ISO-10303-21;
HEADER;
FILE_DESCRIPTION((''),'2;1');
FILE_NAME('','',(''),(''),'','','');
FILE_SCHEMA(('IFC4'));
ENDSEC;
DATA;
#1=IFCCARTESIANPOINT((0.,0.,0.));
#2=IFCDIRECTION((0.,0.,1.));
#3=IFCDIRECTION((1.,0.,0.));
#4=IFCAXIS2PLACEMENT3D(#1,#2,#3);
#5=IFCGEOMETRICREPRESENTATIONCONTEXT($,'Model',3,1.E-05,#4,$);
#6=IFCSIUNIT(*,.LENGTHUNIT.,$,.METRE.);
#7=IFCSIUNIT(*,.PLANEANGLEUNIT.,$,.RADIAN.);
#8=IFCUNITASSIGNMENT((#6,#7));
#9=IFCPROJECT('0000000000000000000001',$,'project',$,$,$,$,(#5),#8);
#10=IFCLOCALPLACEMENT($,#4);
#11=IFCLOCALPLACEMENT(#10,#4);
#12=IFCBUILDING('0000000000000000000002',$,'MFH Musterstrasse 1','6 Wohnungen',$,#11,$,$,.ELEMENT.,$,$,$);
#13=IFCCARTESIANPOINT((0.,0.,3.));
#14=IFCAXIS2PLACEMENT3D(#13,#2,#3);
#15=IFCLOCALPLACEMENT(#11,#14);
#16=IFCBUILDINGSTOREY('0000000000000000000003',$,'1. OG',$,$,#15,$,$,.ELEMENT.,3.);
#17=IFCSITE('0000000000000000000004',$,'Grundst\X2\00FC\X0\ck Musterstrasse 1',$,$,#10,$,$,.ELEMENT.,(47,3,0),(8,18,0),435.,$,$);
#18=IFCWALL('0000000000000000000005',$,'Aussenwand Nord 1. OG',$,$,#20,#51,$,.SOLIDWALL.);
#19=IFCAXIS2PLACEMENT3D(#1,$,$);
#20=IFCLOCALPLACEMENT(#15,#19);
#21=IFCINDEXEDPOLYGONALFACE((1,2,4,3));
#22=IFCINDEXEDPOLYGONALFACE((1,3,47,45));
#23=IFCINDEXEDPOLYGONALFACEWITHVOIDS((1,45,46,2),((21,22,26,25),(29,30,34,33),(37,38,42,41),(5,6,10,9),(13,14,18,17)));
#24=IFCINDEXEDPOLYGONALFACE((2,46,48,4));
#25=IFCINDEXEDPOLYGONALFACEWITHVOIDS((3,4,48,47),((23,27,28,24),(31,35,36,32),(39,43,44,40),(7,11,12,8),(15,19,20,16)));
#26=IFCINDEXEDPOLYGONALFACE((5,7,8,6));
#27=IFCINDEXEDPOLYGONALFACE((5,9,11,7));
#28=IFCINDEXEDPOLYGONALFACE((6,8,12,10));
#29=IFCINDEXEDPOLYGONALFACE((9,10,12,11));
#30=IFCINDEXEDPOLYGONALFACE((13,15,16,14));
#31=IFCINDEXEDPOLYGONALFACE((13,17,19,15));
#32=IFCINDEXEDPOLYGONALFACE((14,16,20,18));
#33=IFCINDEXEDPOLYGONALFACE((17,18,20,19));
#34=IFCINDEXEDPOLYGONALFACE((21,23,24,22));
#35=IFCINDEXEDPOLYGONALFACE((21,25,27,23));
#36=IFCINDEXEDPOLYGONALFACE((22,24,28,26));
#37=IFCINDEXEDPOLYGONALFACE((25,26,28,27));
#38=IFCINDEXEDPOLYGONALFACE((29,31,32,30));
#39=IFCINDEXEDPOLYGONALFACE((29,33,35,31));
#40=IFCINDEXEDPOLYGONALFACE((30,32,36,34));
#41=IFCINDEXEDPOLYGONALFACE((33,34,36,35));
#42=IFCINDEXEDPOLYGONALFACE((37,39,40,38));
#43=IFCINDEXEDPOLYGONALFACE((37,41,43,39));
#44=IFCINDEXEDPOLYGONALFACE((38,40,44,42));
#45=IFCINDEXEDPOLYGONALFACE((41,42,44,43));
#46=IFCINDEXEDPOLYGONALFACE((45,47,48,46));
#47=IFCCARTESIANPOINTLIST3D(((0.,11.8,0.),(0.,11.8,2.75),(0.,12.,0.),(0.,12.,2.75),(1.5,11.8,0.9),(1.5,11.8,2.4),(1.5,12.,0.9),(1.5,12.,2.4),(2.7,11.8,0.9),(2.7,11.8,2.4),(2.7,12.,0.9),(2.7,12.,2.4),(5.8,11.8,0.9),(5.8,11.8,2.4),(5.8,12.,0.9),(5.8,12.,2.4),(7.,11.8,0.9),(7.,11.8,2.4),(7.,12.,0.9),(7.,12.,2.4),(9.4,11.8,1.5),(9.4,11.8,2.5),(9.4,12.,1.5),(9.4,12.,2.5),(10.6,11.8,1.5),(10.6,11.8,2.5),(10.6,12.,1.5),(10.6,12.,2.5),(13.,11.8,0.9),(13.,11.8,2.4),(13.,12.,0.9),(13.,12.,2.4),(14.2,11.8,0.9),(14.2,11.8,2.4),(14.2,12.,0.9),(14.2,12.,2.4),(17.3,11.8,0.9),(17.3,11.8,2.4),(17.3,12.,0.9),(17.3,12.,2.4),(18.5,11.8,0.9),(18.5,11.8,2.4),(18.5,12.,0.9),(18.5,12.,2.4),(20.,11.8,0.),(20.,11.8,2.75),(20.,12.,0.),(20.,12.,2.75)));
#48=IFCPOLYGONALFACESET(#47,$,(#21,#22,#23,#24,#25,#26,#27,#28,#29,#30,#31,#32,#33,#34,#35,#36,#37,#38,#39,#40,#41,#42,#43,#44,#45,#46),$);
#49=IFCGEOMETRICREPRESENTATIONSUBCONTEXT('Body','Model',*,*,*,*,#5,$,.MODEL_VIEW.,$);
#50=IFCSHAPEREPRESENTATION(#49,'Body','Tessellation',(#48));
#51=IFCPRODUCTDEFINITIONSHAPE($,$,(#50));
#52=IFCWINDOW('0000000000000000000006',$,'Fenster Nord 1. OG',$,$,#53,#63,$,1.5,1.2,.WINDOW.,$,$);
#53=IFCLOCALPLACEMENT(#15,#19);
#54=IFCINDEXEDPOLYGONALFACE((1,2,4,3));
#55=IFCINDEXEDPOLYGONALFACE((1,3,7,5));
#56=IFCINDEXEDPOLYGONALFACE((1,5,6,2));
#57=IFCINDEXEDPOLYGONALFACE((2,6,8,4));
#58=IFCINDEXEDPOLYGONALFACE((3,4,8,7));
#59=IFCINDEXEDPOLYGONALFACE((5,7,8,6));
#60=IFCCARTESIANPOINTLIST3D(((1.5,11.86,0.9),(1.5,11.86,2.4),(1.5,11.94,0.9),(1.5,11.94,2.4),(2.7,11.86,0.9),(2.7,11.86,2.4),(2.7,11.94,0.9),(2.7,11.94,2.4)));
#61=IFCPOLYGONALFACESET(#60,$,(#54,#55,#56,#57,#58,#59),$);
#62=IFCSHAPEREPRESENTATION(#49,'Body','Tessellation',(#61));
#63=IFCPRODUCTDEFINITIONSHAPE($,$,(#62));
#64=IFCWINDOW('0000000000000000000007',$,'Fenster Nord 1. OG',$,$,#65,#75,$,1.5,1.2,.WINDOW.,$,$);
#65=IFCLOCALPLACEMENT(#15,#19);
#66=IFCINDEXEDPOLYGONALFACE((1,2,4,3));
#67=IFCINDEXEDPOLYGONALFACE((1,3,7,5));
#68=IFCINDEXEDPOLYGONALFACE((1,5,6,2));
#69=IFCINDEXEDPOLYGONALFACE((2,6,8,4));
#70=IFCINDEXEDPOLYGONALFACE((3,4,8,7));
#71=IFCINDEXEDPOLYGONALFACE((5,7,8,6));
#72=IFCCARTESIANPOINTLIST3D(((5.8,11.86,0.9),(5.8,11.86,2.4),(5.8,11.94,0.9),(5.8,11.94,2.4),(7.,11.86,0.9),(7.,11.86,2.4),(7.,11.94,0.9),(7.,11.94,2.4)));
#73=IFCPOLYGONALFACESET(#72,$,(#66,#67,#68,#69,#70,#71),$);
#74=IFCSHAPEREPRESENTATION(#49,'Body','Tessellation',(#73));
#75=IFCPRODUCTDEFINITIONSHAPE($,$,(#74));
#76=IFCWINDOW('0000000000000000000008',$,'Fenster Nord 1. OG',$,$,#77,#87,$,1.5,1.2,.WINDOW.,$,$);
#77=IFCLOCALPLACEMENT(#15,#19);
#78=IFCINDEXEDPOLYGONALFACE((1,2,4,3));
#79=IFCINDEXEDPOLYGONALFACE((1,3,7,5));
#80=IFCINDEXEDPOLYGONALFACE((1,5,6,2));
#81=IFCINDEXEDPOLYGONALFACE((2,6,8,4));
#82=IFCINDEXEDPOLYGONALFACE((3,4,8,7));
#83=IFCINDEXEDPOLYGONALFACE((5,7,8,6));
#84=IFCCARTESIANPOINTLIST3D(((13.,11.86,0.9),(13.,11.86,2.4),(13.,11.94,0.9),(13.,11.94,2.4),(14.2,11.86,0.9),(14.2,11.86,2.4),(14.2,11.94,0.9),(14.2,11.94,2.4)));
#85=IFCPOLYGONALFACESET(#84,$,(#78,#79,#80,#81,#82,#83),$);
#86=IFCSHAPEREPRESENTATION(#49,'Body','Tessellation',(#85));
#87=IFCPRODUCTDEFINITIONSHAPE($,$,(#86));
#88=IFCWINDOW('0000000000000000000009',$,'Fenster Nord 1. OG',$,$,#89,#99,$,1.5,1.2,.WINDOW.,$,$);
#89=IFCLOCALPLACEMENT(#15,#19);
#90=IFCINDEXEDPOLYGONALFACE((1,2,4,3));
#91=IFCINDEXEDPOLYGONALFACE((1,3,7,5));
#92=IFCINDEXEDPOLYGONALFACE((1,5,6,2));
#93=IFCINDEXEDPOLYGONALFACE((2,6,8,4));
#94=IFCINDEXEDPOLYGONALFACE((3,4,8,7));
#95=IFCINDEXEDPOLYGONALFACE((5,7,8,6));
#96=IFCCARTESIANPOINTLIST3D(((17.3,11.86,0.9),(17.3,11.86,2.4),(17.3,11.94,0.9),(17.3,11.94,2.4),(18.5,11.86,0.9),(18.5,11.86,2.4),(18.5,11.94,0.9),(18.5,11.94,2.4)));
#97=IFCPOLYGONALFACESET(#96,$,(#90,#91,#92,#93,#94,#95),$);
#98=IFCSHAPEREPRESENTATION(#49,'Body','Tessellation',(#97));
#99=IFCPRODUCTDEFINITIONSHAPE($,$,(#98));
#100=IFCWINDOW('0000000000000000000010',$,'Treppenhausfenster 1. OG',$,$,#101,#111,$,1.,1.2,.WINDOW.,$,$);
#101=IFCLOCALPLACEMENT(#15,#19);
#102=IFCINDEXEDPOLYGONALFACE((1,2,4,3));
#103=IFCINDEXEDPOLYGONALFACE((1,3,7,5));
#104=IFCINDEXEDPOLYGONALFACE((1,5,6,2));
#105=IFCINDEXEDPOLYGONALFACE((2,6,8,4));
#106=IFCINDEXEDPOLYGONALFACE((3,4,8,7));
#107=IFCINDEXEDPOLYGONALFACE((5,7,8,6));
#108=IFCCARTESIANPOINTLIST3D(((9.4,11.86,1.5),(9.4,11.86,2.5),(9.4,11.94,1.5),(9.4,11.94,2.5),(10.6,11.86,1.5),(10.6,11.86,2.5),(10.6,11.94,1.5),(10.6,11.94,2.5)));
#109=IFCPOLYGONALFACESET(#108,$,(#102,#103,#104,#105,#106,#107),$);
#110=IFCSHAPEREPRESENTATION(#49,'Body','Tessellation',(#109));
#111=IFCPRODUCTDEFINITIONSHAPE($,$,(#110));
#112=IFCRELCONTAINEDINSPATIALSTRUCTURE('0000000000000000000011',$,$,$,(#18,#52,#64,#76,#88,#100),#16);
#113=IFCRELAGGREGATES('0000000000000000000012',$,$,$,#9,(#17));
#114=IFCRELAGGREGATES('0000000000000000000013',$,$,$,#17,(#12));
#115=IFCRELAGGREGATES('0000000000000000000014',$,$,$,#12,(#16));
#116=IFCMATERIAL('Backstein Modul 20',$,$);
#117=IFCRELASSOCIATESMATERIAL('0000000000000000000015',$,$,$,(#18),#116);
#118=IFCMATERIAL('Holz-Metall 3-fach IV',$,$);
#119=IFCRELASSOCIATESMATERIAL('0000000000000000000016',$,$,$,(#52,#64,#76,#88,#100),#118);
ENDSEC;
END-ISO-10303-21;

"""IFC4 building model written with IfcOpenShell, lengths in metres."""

from ifc_helpers import new_model, si_unit, frame, frame_2d, origin_with_axes, place, context, subcontext, project, spatial, rectangle, extrude, material, element, fill, save


model = new_model("IFC4")

# Units and contexts
model_context = context("Model", 3, precision=1e-05, world=origin_with_axes())
body_context = subcontext(model_context, "Body", "Model", "MODEL_VIEW")
ifc_project = project(units=[si_unit("LENGTHUNIT", "METRE"), si_unit("PLANEANGLEUNIT", "RADIAN")], contexts=[model_context])

# Site, building, storey
site_placement = place(None, origin_with_axes())
site = spatial("IfcSite", under=ifc_project, at=site_placement, Name="Grundstück Musterstrasse 1", CompositionType="ELEMENT", RefLatitude=(47, 3, 0), RefLongitude=(8, 18, 0), RefElevation=435.0)
building_placement = place(site_placement, origin_with_axes())
building = spatial("IfcBuilding", under=site, at=building_placement, Name="MFH Musterstrasse 1", Description="6 Wohnungen", CompositionType="ELEMENT")
storey_placement = place(building_placement, frame((0.0, 0.0, 3.0), z_axis=(0.0, 0.0, 1.0), x_axis=(1.0, 0.0, 0.0)))
storey = spatial("IfcBuildingStorey", under=building, at=storey_placement, Name="1. OG", CompositionType="ELEMENT", Elevation=3.0)

# Shared definitions
ifc_material_1 = material(Name="Backstein Modul 20")
ifc_material_2 = material(Name="Holz-Metall 3-fach IV")

# Wall, openings, windows
wall_1_placement = place(storey_placement, origin_with_axes())
wall_1 = element("IfcWall", 1, at=wall_1_placement, inside=storey, material=ifc_material_1, Name="Aussenwand Nord 1. OG", PredefinedType="SOLIDWALL", context=body_context, shape_type="SweptSolid", body=[
    extrude(rectangle(XDim=20.0, YDim=0.2, at=frame_2d((10.0, 0.1), x_axis=(1.0, 0.0))), frame((0.0, 11.8, 0.0), z_axis=(0.0, 0.0, 1.0), x_axis=(1.0, 0.0, 0.0)), (0.0, 0.0, 1.0), 2.75),
])
opening_1_placement = place(storey_placement, origin_with_axes())
element("IfcOpeningElement", 2, at=opening_1_placement, cuts=wall_1, PredefinedType="OPENING", context=body_context, shape_type="SweptSolid", body=[
    extrude(rectangle(XDim=1.2, YDim=0.3, at=frame_2d((0.6, 0.15), x_axis=(1.0, 0.0))), frame((1.5, 11.75, 0.9), z_axis=(0.0, 0.0, 1.0), x_axis=(1.0, 0.0, 0.0)), (0.0, 0.0, 1.0), 1.5),
])
opening_2_placement = place(storey_placement, origin_with_axes())
element("IfcOpeningElement", 3, at=opening_2_placement, cuts=wall_1, PredefinedType="OPENING", context=body_context, shape_type="SweptSolid", body=[
    extrude(rectangle(XDim=1.2, YDim=0.3, at=frame_2d((0.6, 0.15), x_axis=(1.0, 0.0))), frame((5.8, 11.75, 0.9), z_axis=(0.0, 0.0, 1.0), x_axis=(1.0, 0.0, 0.0)), (0.0, 0.0, 1.0), 1.5),
])
opening_3_placement = place(storey_placement, origin_with_axes())
element("IfcOpeningElement", 4, at=opening_3_placement, cuts=wall_1, PredefinedType="OPENING", context=body_context, shape_type="SweptSolid", body=[
    extrude(rectangle(XDim=1.2, YDim=0.3, at=frame_2d((0.6, 0.15), x_axis=(1.0, 0.0))), frame((13.0, 11.75, 0.9), z_axis=(0.0, 0.0, 1.0), x_axis=(1.0, 0.0, 0.0)), (0.0, 0.0, 1.0), 1.5),
])
opening_4_placement = place(storey_placement, origin_with_axes())
element("IfcOpeningElement", 5, at=opening_4_placement, cuts=wall_1, PredefinedType="OPENING", context=body_context, shape_type="SweptSolid", body=[
    extrude(rectangle(XDim=1.2, YDim=0.3, at=frame_2d((0.6, 0.15), x_axis=(1.0, 0.0))), frame((17.3, 11.75, 0.9), z_axis=(0.0, 0.0, 1.0), x_axis=(1.0, 0.0, 0.0)), (0.0, 0.0, 1.0), 1.5),
])
opening_5_placement = place(storey_placement, origin_with_axes())
element("IfcOpeningElement", 6, at=opening_5_placement, cuts=wall_1, PredefinedType="OPENING", context=body_context, shape_type="SweptSolid", body=[
    extrude(rectangle(XDim=1.2, YDim=0.3, at=frame_2d((0.6, 0.15), x_axis=(1.0, 0.0))), frame((9.4, 11.75, 1.5), z_axis=(0.0, 0.0, 1.0), x_axis=(1.0, 0.0, 0.0)), (0.0, 0.0, 1.0), 1.0),
])
opening_6_placement = place(storey_placement, origin_with_axes())
opening_6 = element("IfcOpeningElement", 7, at=opening_6_placement, cuts=wall_1, PredefinedType="OPENING", context=body_context, shape_type="SweptSolid", body=[
    extrude(rectangle(XDim=1.2, YDim=0.22, at=frame_2d((0.6, 0.11), x_axis=(1.0, 0.0))), frame((1.5, 11.79, 0.9), z_axis=(0.0, 0.0, 1.0), x_axis=(1.0, 0.0, 0.0)), (0.0, 0.0, 1.0), 1.5),
])
opening_7_placement = place(storey_placement, origin_with_axes())
opening_7 = element("IfcOpeningElement", 8, at=opening_7_placement, cuts=wall_1, PredefinedType="OPENING", context=body_context, shape_type="SweptSolid", body=[
    extrude(rectangle(XDim=1.2, YDim=0.22, at=frame_2d((0.6, 0.11), x_axis=(1.0, 0.0))), frame((5.8, 11.79, 0.9), z_axis=(0.0, 0.0, 1.0), x_axis=(1.0, 0.0, 0.0)), (0.0, 0.0, 1.0), 1.5),
])
opening_8_placement = place(storey_placement, origin_with_axes())
opening_8 = element("IfcOpeningElement", 9, at=opening_8_placement, cuts=wall_1, PredefinedType="OPENING", context=body_context, shape_type="SweptSolid", body=[
    extrude(rectangle(XDim=1.2, YDim=0.22, at=frame_2d((0.6, 0.11), x_axis=(1.0, 0.0))), frame((13.0, 11.79, 0.9), z_axis=(0.0, 0.0, 1.0), x_axis=(1.0, 0.0, 0.0)), (0.0, 0.0, 1.0), 1.5),
])
opening_9_placement = place(storey_placement, origin_with_axes())
opening_9 = element("IfcOpeningElement", 10, at=opening_9_placement, cuts=wall_1, PredefinedType="OPENING", context=body_context, shape_type="SweptSolid", body=[
    extrude(rectangle(XDim=1.2, YDim=0.22, at=frame_2d((0.6, 0.11), x_axis=(1.0, 0.0))), frame((17.3, 11.79, 0.9), z_axis=(0.0, 0.0, 1.0), x_axis=(1.0, 0.0, 0.0)), (0.0, 0.0, 1.0), 1.5),
])
opening_10_placement = place(storey_placement, origin_with_axes())
opening_10 = element("IfcOpeningElement", 11, at=opening_10_placement, cuts=wall_1, PredefinedType="OPENING", context=body_context, shape_type="SweptSolid", body=[
    extrude(rectangle(XDim=1.2, YDim=0.22, at=frame_2d((0.6, 0.11), x_axis=(1.0, 0.0))), frame((9.4, 11.79, 1.5), z_axis=(0.0, 0.0, 1.0), x_axis=(1.0, 0.0, 0.0)), (0.0, 0.0, 1.0), 1.0),
])
window_1_placement = place(storey_placement, origin_with_axes())
window_1 = element("IfcWindow", 12, at=window_1_placement, inside=storey, material=ifc_material_2, Name="Fenster Nord 1. OG", OverallHeight=1.5, OverallWidth=1.2, PredefinedType="WINDOW", context=body_context, shape_type="SweptSolid", body=[
    extrude(rectangle(XDim=1.2, YDim=0.08, at=frame_2d((0.6, 0.04), x_axis=(1.0, 0.0))), frame((1.5, 11.86, 0.9), z_axis=(0.0, 0.0, 1.0), x_axis=(1.0, 0.0, 0.0)), (0.0, 0.0, 1.0), 1.5),
])
fill(opening_6, window_1)
window_2_placement = place(storey_placement, origin_with_axes())
window_2 = element("IfcWindow", 13, at=window_2_placement, inside=storey, material=ifc_material_2, Name="Fenster Nord 1. OG", OverallHeight=1.5, OverallWidth=1.2, PredefinedType="WINDOW", context=body_context, shape_type="SweptSolid", body=[
    extrude(rectangle(XDim=1.2, YDim=0.08, at=frame_2d((0.6, 0.04), x_axis=(1.0, 0.0))), frame((5.8, 11.86, 0.9), z_axis=(0.0, 0.0, 1.0), x_axis=(1.0, 0.0, 0.0)), (0.0, 0.0, 1.0), 1.5),
])
fill(opening_7, window_2)
window_3_placement = place(storey_placement, origin_with_axes())
window_3 = element("IfcWindow", 14, at=window_3_placement, inside=storey, material=ifc_material_2, Name="Fenster Nord 1. OG", OverallHeight=1.5, OverallWidth=1.2, PredefinedType="WINDOW", context=body_context, shape_type="SweptSolid", body=[
    extrude(rectangle(XDim=1.2, YDim=0.08, at=frame_2d((0.6, 0.04), x_axis=(1.0, 0.0))), frame((13.0, 11.86, 0.9), z_axis=(0.0, 0.0, 1.0), x_axis=(1.0, 0.0, 0.0)), (0.0, 0.0, 1.0), 1.5),
])
fill(opening_8, window_3)
window_4_placement = place(storey_placement, origin_with_axes())
window_4 = element("IfcWindow", 15, at=window_4_placement, inside=storey, material=ifc_material_2, Name="Fenster Nord 1. OG", OverallHeight=1.5, OverallWidth=1.2, PredefinedType="WINDOW", context=body_context, shape_type="SweptSolid", body=[
    extrude(rectangle(XDim=1.2, YDim=0.08, at=frame_2d((0.6, 0.04), x_axis=(1.0, 0.0))), frame((17.3, 11.86, 0.9), z_axis=(0.0, 0.0, 1.0), x_axis=(1.0, 0.0, 0.0)), (0.0, 0.0, 1.0), 1.5),
])
fill(opening_9, window_4)
window_5_placement = place(storey_placement, origin_with_axes())
window_5 = element("IfcWindow", 16, at=window_5_placement, inside=storey, material=ifc_material_2, Name="Treppenhausfenster 1. OG", OverallHeight=1.0, OverallWidth=1.2, PredefinedType="WINDOW", context=body_context, shape_type="SweptSolid", body=[
    extrude(rectangle(XDim=1.2, YDim=0.08, at=frame_2d((0.6, 0.04), x_axis=(1.0, 0.0))), frame((9.4, 11.86, 1.5), z_axis=(0.0, 0.0, 1.0), x_axis=(1.0, 0.0, 0.0)), (0.0, 0.0, 1.0), 1.0),
])
fill(opening_10, window_5)

save(model, "model.ifc")
